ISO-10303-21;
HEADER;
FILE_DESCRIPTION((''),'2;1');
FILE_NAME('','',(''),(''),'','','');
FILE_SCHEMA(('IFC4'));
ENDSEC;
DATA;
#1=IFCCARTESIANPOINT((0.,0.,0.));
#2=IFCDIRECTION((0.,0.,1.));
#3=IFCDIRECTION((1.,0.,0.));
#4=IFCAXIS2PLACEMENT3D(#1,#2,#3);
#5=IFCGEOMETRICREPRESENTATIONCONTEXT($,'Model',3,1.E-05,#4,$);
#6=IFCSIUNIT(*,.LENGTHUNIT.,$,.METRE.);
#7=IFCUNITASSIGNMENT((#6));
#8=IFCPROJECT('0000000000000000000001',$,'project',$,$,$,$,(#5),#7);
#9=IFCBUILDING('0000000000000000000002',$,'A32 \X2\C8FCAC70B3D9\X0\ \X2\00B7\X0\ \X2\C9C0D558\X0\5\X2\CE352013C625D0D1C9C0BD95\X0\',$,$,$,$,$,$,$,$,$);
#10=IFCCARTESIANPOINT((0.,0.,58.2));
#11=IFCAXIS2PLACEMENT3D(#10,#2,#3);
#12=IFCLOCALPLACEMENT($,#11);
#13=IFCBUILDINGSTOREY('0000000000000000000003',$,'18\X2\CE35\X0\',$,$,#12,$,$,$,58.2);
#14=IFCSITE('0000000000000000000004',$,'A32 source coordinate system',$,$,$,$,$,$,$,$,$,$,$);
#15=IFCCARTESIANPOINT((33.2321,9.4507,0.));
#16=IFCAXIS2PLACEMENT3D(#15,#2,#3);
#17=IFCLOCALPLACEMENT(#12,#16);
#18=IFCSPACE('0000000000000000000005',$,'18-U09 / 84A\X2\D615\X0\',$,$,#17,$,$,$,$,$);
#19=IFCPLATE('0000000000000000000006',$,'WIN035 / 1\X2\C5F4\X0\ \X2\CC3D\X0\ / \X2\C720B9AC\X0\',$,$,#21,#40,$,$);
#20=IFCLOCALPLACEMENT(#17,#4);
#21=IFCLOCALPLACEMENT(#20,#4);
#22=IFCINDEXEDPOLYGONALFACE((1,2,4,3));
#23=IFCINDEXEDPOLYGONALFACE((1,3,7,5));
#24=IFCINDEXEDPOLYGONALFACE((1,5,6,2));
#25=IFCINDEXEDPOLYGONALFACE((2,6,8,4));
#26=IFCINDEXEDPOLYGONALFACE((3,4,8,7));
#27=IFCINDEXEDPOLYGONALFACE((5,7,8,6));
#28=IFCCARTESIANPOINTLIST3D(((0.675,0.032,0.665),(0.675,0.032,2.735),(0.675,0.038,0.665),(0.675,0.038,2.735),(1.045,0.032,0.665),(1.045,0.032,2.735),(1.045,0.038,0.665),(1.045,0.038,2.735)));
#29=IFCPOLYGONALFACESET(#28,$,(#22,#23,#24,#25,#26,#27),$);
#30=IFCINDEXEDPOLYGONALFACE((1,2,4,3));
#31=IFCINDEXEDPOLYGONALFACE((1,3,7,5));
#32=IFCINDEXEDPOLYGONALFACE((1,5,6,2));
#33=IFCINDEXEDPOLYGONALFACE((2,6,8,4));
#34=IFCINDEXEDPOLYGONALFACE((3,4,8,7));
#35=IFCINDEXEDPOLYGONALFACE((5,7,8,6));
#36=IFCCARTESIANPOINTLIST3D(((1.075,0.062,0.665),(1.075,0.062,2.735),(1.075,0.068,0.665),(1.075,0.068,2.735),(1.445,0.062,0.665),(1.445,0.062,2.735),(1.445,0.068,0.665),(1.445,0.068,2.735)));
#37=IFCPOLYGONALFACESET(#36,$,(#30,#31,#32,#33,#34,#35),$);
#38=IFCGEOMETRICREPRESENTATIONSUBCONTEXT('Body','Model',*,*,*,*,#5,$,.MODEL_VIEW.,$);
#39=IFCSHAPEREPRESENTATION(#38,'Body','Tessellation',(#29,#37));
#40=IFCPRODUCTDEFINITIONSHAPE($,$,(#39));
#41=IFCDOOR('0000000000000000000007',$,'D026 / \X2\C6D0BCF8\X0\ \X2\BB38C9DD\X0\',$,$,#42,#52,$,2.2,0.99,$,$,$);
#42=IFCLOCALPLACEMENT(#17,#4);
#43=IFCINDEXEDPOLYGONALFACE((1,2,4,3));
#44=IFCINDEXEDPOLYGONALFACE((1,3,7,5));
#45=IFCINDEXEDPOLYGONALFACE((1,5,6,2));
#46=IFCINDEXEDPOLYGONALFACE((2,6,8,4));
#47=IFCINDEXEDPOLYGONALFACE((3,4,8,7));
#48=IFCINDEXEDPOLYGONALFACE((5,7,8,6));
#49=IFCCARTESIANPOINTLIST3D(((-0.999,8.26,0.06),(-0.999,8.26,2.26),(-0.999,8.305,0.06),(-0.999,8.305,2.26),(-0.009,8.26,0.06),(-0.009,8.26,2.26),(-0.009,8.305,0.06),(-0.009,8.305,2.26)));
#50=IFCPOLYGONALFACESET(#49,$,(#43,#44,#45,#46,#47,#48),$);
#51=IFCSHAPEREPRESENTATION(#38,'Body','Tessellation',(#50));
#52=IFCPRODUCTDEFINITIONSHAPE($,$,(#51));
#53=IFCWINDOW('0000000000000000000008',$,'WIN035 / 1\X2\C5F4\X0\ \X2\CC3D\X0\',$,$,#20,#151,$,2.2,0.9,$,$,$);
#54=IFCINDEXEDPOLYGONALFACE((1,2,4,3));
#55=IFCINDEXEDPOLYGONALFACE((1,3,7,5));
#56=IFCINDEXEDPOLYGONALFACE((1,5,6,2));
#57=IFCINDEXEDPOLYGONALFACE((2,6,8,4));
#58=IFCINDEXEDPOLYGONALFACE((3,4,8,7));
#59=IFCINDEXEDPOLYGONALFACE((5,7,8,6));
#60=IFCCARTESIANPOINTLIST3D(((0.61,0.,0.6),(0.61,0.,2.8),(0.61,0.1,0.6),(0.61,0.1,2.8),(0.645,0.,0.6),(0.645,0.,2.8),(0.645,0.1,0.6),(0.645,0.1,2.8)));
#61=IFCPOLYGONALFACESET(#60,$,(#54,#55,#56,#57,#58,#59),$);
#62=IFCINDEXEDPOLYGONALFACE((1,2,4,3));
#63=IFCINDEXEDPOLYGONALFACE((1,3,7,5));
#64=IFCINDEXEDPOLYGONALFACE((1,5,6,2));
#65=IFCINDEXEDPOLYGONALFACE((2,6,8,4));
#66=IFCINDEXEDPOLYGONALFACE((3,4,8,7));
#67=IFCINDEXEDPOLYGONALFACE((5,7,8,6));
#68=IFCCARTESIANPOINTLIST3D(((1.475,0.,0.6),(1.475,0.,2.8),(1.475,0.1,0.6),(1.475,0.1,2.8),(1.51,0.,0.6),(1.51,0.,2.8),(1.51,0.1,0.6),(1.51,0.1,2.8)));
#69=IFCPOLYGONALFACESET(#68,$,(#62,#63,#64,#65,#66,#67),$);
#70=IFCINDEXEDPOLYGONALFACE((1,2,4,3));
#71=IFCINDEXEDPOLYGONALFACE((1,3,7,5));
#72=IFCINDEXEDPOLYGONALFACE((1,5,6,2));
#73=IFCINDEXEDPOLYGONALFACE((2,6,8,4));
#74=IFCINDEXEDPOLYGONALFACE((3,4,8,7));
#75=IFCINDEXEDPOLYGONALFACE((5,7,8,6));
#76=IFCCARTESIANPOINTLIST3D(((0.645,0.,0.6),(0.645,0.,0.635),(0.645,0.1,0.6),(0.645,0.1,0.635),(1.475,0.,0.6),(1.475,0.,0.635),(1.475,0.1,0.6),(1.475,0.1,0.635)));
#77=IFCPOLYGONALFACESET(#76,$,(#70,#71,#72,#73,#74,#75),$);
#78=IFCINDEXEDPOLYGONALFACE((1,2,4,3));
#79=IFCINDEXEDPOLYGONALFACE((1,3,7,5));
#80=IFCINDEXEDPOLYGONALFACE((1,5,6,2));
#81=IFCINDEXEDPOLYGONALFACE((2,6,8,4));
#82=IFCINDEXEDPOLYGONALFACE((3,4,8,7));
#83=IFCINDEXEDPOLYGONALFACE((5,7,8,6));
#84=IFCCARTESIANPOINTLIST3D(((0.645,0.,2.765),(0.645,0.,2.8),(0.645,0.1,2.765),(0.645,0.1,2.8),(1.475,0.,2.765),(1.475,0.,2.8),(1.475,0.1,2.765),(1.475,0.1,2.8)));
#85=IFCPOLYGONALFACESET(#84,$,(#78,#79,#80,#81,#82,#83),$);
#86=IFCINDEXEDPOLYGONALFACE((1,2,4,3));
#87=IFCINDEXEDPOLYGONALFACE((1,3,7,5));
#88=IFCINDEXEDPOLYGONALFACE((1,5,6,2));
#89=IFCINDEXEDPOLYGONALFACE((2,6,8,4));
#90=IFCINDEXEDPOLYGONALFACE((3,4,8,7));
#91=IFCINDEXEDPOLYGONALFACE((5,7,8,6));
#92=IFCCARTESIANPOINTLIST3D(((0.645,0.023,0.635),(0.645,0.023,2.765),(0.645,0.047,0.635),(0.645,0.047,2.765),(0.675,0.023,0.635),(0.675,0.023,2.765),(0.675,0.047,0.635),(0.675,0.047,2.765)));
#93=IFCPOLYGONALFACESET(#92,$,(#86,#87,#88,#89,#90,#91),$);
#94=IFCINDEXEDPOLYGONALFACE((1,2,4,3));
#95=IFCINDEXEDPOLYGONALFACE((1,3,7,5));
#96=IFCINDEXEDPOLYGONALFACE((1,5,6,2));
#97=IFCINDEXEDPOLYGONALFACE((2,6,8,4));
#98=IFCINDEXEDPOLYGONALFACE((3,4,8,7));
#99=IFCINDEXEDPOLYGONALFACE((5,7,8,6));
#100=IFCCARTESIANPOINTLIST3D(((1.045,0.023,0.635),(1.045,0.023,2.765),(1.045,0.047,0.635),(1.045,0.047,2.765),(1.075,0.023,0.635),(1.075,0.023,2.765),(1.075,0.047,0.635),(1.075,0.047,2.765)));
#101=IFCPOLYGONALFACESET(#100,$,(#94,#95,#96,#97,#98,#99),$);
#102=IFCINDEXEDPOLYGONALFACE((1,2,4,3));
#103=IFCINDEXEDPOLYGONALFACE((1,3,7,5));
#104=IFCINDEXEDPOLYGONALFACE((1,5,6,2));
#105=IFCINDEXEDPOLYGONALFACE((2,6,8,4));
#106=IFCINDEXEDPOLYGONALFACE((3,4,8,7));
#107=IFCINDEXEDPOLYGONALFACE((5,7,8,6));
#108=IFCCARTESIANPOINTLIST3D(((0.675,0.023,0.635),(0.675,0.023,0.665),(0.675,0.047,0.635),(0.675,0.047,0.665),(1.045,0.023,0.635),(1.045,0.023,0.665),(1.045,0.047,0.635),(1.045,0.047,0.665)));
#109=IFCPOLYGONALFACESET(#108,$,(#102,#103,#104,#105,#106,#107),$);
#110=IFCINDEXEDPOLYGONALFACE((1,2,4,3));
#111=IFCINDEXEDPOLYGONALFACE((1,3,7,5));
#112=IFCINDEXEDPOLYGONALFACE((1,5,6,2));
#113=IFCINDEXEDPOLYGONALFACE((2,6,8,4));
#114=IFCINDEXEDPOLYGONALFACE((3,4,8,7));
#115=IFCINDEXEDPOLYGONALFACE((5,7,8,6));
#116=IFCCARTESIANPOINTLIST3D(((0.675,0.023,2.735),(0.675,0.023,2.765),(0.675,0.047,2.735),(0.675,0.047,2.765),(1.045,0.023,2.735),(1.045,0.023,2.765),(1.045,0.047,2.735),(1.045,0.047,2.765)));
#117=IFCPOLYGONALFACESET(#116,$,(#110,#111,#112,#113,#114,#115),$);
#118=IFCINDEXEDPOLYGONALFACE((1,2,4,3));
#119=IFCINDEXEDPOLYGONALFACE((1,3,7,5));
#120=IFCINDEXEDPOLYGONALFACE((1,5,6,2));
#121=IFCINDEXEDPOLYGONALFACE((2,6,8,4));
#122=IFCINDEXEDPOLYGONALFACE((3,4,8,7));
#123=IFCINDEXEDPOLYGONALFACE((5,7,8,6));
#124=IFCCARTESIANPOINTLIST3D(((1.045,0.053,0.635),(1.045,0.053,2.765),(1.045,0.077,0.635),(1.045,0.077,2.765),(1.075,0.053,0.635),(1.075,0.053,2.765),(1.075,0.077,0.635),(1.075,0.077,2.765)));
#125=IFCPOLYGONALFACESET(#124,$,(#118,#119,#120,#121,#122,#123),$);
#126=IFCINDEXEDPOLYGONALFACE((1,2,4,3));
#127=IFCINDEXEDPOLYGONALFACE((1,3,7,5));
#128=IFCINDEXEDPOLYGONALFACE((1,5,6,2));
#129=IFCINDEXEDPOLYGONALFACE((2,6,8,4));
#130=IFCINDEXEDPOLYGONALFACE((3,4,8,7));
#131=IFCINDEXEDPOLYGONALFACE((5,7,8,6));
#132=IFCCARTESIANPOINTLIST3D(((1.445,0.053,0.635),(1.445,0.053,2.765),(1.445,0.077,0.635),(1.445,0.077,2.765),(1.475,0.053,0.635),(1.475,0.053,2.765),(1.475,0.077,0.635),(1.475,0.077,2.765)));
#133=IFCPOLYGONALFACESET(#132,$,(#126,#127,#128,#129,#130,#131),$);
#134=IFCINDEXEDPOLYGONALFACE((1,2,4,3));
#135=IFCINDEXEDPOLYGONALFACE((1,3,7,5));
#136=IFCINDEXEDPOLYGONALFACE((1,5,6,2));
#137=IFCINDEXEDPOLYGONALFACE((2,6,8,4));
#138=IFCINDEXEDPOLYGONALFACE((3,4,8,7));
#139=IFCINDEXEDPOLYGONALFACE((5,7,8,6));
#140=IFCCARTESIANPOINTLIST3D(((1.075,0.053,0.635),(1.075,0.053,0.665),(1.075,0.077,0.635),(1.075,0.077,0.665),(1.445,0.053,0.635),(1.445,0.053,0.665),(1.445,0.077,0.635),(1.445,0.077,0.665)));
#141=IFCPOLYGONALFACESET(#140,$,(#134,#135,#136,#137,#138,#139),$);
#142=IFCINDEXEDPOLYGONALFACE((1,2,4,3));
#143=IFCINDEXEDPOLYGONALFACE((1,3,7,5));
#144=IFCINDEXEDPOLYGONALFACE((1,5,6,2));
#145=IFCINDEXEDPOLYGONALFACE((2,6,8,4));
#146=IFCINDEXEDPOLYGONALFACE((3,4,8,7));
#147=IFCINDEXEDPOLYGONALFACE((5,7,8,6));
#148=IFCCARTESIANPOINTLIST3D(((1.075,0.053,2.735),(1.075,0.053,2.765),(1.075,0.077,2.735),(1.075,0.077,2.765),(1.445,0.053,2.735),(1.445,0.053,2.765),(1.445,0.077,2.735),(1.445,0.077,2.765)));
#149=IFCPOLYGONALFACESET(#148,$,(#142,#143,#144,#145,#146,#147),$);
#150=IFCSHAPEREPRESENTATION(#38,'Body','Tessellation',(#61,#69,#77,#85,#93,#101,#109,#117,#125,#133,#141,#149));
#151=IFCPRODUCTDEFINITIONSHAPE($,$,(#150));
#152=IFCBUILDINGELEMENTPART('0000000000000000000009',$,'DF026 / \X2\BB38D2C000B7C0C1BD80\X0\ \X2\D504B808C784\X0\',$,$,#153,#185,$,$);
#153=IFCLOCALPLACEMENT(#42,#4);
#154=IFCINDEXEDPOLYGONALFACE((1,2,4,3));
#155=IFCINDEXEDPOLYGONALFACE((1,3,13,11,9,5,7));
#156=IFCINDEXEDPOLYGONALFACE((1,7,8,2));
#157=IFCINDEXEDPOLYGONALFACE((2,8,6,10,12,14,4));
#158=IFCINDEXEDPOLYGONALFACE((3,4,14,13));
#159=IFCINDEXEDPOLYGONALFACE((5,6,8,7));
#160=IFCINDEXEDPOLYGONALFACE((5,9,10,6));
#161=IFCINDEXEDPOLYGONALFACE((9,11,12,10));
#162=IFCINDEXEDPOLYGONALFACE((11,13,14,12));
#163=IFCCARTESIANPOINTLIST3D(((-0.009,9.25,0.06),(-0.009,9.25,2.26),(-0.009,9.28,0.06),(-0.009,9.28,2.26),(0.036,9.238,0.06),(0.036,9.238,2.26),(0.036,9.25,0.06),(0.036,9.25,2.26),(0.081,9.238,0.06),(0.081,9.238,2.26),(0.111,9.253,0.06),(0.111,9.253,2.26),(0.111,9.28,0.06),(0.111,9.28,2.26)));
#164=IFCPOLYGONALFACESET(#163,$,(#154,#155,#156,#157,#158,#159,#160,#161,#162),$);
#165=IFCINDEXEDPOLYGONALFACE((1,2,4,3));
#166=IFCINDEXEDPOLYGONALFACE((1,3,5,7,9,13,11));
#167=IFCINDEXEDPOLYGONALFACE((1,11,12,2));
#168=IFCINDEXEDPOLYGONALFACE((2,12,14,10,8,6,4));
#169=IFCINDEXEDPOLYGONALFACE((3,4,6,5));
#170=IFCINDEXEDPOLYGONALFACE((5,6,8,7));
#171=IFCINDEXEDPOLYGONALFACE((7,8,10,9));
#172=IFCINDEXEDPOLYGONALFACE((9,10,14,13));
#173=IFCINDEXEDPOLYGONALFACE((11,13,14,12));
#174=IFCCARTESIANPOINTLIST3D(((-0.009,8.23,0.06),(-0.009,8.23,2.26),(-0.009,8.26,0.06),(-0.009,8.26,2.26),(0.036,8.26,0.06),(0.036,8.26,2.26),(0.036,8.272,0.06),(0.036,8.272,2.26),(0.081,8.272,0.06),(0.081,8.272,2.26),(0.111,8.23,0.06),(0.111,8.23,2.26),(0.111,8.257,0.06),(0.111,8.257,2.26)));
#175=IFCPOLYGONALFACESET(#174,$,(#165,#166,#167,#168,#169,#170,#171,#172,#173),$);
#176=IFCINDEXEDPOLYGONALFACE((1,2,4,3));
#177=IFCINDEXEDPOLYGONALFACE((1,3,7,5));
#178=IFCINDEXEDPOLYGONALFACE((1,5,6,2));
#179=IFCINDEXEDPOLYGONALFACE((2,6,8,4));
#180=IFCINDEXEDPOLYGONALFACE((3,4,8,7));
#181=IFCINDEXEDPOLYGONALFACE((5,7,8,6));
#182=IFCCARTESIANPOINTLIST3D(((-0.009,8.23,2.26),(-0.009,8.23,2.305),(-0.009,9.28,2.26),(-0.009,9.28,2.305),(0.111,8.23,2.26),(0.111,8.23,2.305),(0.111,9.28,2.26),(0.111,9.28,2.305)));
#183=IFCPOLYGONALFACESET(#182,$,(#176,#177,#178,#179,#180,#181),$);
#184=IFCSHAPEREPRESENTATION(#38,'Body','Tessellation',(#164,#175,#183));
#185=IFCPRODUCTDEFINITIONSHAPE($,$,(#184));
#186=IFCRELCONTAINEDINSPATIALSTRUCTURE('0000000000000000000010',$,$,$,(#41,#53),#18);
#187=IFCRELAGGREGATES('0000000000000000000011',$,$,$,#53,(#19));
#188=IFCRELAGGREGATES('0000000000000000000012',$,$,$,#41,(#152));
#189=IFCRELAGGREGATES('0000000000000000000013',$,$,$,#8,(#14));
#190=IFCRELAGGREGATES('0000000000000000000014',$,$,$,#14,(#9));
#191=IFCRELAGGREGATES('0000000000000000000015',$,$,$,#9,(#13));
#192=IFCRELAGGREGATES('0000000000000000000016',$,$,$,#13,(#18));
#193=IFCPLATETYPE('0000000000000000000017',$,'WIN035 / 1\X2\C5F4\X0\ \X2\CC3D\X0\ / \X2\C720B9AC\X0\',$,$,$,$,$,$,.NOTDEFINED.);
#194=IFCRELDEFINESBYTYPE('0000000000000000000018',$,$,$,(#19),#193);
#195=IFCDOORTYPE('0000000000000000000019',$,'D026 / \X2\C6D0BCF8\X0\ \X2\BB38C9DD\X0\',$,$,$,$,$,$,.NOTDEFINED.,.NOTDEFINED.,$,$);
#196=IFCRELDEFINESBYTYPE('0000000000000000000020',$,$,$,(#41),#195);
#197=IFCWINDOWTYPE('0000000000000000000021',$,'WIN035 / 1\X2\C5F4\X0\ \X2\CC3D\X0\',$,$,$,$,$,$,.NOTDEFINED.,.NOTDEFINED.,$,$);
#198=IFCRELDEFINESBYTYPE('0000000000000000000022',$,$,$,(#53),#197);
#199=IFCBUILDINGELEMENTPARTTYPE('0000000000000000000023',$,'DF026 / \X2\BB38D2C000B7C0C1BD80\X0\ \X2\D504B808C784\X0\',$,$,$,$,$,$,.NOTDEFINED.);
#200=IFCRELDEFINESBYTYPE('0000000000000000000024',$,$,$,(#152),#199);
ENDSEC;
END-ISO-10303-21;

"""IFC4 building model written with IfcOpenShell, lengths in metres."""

from ifc_helpers import new_model, si_unit, frame, origin, origin_with_axes, place, context, subcontext, project, spatial, polyline, outline, extrude, source, transform, mapped, type_object, type_shapes, element, aggregate, save


model = new_model("IFC4")

# Units and contexts
model_context = context("Model", 3, precision=1e-05, world=origin_with_axes())
body_context = subcontext(model_context, "Body", "Model", "MODEL_VIEW")
ifc_project = project(units=[si_unit("LENGTHUNIT", "METRE")], contexts=[model_context])

# Plate
plate_type_1 = type_object("IfcPlateType", Name="WIN035 / 1열 창 / 유리", PredefinedType="NOTDEFINED")
shared_shape_1 = source(origin(), body_context, "Body", "SweptSolid", [
    extrude(outline(polyline([(0.675, 0.032), (0.675, 0.038), (1.045, 0.038), (1.045, 0.032), (0.675, 0.032)])), frame((0.0, 0.0, 0.665)), (0.0, 0.0, 1.0), 2.07),
    extrude(outline(polyline([(1.075, 0.062), (1.075, 0.068), (1.445, 0.068), (1.445, 0.062), (1.075, 0.062)])), frame((0.0, 0.0, 0.665)), (0.0, 0.0, 1.0), 2.07),
])
type_shapes(plate_type_1, [shared_shape_1])
storey_placement = place(None, frame((0.0, 0.0, 58.2), z_axis=(0.0, 0.0, 1.0), x_axis=(1.0, 0.0, 0.0)))
space_placement = place(storey_placement, frame((33.2321, 9.4507, 0.0), z_axis=(0.0, 0.0, 1.0), x_axis=(1.0, 0.0, 0.0)))
window_1_placement = place(space_placement, origin_with_axes())
plate_1_placement = place(window_1_placement, origin_with_axes())
plate_1 = element("IfcPlate", 1, at=plate_1_placement, type_object=plate_type_1, Name="WIN035 / 1열 창 / 유리", context=body_context, shape_type="MappedRepresentation", body=[
    mapped(shared_shape_1, transform((0.0, 0.0, 0.0), scale=1.0)),
])

# Site, building, storey, space
site = spatial("IfcSite", under=ifc_project, Name="A32 source coordinate system")
building = spatial("IfcBuilding", under=site, Name="A32 주거동 · 지하5층–옥탑지붕")
storey = spatial("IfcBuildingStorey", under=building, at=storey_placement, Name="18층", Elevation=58.2)
space = spatial("IfcSpace", under=storey, at=space_placement, Name="18-U09 / 84A형")

# Door
door_type_1 = type_object("IfcDoorType", Name="D026 / 원본 문짝", OperationType="NOTDEFINED", PredefinedType="NOTDEFINED")
shared_shape_2 = source(origin(), body_context, "Body", "SweptSolid", [
    extrude(outline(polyline([(-0.009, 8.26), (-0.999, 8.26), (-0.999, 8.305), (-0.009, 8.305), (-0.009, 8.26)])), frame((0.0, 0.0, 0.06)), (0.0, 0.0, 1.0), 2.2),
])
type_shapes(door_type_1, [shared_shape_2])
door_1_placement = place(space_placement, origin_with_axes())
door_1 = element("IfcDoor", 2, at=door_1_placement, inside=space, type_object=door_type_1, Name="D026 / 원본 문짝", OverallHeight=2.2, OverallWidth=0.99, context=body_context, shape_type="MappedRepresentation", body=[
    mapped(shared_shape_2, transform((0.0, 0.0, 0.0), scale=1.0)),
])

# Window
window_type_1 = type_object("IfcWindowType", Name="WIN035 / 1열 창", PartitioningType="NOTDEFINED", PredefinedType="NOTDEFINED")
shared_shape_3 = source(origin(), body_context, "Body", "SweptSolid", [
    extrude(outline(polyline([(0.61, 0.0), (0.61, 0.1), (0.645, 0.1), (0.645, 0.0), (0.61, 0.0)])), frame((0.0, 0.0, 0.6)), (0.0, 0.0, 1.0), 2.2),
    extrude(outline(polyline([(1.475, 0.0), (1.475, 0.1), (1.51, 0.1), (1.51, 0.0), (1.475, 0.0)])), frame((0.0, 0.0, 0.6)), (0.0, 0.0, 1.0), 2.2),
    extrude(outline(polyline([(0.645, 0.0), (0.645, 0.1), (1.475, 0.1), (1.475, 0.0), (0.645, 0.0)])), frame((0.0, 0.0, 0.6)), (0.0, 0.0, 1.0), 0.035),
    extrude(outline(polyline([(0.645, 0.0), (0.645, 0.1), (1.475, 0.1), (1.475, 0.0), (0.645, 0.0)])), frame((0.0, 0.0, 2.765)), (0.0, 0.0, 1.0), 0.035),
    extrude(outline(polyline([(0.645, 0.023), (0.645, 0.047), (0.675, 0.047), (0.675, 0.023), (0.645, 0.023)])), frame((0.0, 0.0, 0.635)), (0.0, 0.0, 1.0), 2.13),
    extrude(outline(polyline([(1.045, 0.023), (1.045, 0.047), (1.075, 0.047), (1.075, 0.023), (1.045, 0.023)])), frame((0.0, 0.0, 0.635)), (0.0, 0.0, 1.0), 2.13),
    extrude(outline(polyline([(0.675, 0.023), (0.675, 0.047), (1.045, 0.047), (1.045, 0.023), (0.675, 0.023)])), frame((0.0, 0.0, 0.635)), (0.0, 0.0, 1.0), 0.03),
    extrude(outline(polyline([(0.675, 0.023), (0.675, 0.047), (1.045, 0.047), (1.045, 0.023), (0.675, 0.023)])), frame((0.0, 0.0, 2.735)), (0.0, 0.0, 1.0), 0.03),
    extrude(outline(polyline([(1.045, 0.053), (1.045, 0.077), (1.075, 0.077), (1.075, 0.053), (1.045, 0.053)])), frame((0.0, 0.0, 0.635)), (0.0, 0.0, 1.0), 2.13),
    extrude(outline(polyline([(1.445, 0.053), (1.445, 0.077), (1.475, 0.077), (1.475, 0.053), (1.445, 0.053)])), frame((0.0, 0.0, 0.635)), (0.0, 0.0, 1.0), 2.13),
    extrude(outline(polyline([(1.075, 0.053), (1.075, 0.077), (1.445, 0.077), (1.445, 0.053), (1.075, 0.053)])), frame((0.0, 0.0, 0.635)), (0.0, 0.0, 1.0), 0.03),
    extrude(outline(polyline([(1.075, 0.053), (1.075, 0.077), (1.445, 0.077), (1.445, 0.053), (1.075, 0.053)])), frame((0.0, 0.0, 2.735)), (0.0, 0.0, 1.0), 0.03),
])
type_shapes(window_type_1, [shared_shape_3])
window_1 = element("IfcWindow", 3, at=window_1_placement, inside=space, type_object=window_type_1, Name="WIN035 / 1열 창", OverallHeight=2.2, OverallWidth=0.9, context=body_context, shape_type="MappedRepresentation", body=[
    mapped(shared_shape_3, transform((0.0, 0.0, 0.0), scale=1.0)),
])
aggregate(window_1, [plate_1])

# Building element part
building_element_part_type_1 = type_object("IfcBuildingElementPartType", Name="DF026 / 문틀·상부 프레임", PredefinedType="NOTDEFINED")
shared_shape_4 = source(origin(), body_context, "Body", "SweptSolid", [
    extrude(outline(polyline([(0.111, 9.28), (0.111, 9.253), (0.081, 9.238), (0.036, 9.238), (0.036, 9.25), (-0.009, 9.25), (-0.009, 9.28), (0.111, 9.28)])), frame((0.0, 0.0, 0.06)), (0.0, 0.0, 1.0), 2.2),
    extrude(outline(polyline([(-0.009, 8.26), (0.036, 8.26), (0.036, 8.272), (0.081, 8.272), (0.111, 8.257), (0.111, 8.23), (-0.009, 8.23), (-0.009, 8.26)])), frame((0.0, 0.0, 0.06)), (0.0, 0.0, 1.0), 2.2),
    extrude(outline(polyline([(-0.009, 8.23), (-0.009, 9.28), (0.111, 9.28), (0.111, 8.23), (-0.009, 8.23)])), frame((0.0, 0.0, 2.26)), (0.0, 0.0, 1.0), 0.045),
])
type_shapes(building_element_part_type_1, [shared_shape_4])
building_element_part_1_placement = place(door_1_placement, origin_with_axes())
building_element_part_1 = element("IfcBuildingElementPart", 4, at=building_element_part_1_placement, type_object=building_element_part_type_1, Name="DF026 / 문틀·상부 프레임", context=body_context, shape_type="MappedRepresentation", body=[
    mapped(shared_shape_4, transform((0.0, 0.0, 0.0), scale=1.0)),
])
aggregate(door_1, [building_element_part_1])

save(model, "model.ifc")
